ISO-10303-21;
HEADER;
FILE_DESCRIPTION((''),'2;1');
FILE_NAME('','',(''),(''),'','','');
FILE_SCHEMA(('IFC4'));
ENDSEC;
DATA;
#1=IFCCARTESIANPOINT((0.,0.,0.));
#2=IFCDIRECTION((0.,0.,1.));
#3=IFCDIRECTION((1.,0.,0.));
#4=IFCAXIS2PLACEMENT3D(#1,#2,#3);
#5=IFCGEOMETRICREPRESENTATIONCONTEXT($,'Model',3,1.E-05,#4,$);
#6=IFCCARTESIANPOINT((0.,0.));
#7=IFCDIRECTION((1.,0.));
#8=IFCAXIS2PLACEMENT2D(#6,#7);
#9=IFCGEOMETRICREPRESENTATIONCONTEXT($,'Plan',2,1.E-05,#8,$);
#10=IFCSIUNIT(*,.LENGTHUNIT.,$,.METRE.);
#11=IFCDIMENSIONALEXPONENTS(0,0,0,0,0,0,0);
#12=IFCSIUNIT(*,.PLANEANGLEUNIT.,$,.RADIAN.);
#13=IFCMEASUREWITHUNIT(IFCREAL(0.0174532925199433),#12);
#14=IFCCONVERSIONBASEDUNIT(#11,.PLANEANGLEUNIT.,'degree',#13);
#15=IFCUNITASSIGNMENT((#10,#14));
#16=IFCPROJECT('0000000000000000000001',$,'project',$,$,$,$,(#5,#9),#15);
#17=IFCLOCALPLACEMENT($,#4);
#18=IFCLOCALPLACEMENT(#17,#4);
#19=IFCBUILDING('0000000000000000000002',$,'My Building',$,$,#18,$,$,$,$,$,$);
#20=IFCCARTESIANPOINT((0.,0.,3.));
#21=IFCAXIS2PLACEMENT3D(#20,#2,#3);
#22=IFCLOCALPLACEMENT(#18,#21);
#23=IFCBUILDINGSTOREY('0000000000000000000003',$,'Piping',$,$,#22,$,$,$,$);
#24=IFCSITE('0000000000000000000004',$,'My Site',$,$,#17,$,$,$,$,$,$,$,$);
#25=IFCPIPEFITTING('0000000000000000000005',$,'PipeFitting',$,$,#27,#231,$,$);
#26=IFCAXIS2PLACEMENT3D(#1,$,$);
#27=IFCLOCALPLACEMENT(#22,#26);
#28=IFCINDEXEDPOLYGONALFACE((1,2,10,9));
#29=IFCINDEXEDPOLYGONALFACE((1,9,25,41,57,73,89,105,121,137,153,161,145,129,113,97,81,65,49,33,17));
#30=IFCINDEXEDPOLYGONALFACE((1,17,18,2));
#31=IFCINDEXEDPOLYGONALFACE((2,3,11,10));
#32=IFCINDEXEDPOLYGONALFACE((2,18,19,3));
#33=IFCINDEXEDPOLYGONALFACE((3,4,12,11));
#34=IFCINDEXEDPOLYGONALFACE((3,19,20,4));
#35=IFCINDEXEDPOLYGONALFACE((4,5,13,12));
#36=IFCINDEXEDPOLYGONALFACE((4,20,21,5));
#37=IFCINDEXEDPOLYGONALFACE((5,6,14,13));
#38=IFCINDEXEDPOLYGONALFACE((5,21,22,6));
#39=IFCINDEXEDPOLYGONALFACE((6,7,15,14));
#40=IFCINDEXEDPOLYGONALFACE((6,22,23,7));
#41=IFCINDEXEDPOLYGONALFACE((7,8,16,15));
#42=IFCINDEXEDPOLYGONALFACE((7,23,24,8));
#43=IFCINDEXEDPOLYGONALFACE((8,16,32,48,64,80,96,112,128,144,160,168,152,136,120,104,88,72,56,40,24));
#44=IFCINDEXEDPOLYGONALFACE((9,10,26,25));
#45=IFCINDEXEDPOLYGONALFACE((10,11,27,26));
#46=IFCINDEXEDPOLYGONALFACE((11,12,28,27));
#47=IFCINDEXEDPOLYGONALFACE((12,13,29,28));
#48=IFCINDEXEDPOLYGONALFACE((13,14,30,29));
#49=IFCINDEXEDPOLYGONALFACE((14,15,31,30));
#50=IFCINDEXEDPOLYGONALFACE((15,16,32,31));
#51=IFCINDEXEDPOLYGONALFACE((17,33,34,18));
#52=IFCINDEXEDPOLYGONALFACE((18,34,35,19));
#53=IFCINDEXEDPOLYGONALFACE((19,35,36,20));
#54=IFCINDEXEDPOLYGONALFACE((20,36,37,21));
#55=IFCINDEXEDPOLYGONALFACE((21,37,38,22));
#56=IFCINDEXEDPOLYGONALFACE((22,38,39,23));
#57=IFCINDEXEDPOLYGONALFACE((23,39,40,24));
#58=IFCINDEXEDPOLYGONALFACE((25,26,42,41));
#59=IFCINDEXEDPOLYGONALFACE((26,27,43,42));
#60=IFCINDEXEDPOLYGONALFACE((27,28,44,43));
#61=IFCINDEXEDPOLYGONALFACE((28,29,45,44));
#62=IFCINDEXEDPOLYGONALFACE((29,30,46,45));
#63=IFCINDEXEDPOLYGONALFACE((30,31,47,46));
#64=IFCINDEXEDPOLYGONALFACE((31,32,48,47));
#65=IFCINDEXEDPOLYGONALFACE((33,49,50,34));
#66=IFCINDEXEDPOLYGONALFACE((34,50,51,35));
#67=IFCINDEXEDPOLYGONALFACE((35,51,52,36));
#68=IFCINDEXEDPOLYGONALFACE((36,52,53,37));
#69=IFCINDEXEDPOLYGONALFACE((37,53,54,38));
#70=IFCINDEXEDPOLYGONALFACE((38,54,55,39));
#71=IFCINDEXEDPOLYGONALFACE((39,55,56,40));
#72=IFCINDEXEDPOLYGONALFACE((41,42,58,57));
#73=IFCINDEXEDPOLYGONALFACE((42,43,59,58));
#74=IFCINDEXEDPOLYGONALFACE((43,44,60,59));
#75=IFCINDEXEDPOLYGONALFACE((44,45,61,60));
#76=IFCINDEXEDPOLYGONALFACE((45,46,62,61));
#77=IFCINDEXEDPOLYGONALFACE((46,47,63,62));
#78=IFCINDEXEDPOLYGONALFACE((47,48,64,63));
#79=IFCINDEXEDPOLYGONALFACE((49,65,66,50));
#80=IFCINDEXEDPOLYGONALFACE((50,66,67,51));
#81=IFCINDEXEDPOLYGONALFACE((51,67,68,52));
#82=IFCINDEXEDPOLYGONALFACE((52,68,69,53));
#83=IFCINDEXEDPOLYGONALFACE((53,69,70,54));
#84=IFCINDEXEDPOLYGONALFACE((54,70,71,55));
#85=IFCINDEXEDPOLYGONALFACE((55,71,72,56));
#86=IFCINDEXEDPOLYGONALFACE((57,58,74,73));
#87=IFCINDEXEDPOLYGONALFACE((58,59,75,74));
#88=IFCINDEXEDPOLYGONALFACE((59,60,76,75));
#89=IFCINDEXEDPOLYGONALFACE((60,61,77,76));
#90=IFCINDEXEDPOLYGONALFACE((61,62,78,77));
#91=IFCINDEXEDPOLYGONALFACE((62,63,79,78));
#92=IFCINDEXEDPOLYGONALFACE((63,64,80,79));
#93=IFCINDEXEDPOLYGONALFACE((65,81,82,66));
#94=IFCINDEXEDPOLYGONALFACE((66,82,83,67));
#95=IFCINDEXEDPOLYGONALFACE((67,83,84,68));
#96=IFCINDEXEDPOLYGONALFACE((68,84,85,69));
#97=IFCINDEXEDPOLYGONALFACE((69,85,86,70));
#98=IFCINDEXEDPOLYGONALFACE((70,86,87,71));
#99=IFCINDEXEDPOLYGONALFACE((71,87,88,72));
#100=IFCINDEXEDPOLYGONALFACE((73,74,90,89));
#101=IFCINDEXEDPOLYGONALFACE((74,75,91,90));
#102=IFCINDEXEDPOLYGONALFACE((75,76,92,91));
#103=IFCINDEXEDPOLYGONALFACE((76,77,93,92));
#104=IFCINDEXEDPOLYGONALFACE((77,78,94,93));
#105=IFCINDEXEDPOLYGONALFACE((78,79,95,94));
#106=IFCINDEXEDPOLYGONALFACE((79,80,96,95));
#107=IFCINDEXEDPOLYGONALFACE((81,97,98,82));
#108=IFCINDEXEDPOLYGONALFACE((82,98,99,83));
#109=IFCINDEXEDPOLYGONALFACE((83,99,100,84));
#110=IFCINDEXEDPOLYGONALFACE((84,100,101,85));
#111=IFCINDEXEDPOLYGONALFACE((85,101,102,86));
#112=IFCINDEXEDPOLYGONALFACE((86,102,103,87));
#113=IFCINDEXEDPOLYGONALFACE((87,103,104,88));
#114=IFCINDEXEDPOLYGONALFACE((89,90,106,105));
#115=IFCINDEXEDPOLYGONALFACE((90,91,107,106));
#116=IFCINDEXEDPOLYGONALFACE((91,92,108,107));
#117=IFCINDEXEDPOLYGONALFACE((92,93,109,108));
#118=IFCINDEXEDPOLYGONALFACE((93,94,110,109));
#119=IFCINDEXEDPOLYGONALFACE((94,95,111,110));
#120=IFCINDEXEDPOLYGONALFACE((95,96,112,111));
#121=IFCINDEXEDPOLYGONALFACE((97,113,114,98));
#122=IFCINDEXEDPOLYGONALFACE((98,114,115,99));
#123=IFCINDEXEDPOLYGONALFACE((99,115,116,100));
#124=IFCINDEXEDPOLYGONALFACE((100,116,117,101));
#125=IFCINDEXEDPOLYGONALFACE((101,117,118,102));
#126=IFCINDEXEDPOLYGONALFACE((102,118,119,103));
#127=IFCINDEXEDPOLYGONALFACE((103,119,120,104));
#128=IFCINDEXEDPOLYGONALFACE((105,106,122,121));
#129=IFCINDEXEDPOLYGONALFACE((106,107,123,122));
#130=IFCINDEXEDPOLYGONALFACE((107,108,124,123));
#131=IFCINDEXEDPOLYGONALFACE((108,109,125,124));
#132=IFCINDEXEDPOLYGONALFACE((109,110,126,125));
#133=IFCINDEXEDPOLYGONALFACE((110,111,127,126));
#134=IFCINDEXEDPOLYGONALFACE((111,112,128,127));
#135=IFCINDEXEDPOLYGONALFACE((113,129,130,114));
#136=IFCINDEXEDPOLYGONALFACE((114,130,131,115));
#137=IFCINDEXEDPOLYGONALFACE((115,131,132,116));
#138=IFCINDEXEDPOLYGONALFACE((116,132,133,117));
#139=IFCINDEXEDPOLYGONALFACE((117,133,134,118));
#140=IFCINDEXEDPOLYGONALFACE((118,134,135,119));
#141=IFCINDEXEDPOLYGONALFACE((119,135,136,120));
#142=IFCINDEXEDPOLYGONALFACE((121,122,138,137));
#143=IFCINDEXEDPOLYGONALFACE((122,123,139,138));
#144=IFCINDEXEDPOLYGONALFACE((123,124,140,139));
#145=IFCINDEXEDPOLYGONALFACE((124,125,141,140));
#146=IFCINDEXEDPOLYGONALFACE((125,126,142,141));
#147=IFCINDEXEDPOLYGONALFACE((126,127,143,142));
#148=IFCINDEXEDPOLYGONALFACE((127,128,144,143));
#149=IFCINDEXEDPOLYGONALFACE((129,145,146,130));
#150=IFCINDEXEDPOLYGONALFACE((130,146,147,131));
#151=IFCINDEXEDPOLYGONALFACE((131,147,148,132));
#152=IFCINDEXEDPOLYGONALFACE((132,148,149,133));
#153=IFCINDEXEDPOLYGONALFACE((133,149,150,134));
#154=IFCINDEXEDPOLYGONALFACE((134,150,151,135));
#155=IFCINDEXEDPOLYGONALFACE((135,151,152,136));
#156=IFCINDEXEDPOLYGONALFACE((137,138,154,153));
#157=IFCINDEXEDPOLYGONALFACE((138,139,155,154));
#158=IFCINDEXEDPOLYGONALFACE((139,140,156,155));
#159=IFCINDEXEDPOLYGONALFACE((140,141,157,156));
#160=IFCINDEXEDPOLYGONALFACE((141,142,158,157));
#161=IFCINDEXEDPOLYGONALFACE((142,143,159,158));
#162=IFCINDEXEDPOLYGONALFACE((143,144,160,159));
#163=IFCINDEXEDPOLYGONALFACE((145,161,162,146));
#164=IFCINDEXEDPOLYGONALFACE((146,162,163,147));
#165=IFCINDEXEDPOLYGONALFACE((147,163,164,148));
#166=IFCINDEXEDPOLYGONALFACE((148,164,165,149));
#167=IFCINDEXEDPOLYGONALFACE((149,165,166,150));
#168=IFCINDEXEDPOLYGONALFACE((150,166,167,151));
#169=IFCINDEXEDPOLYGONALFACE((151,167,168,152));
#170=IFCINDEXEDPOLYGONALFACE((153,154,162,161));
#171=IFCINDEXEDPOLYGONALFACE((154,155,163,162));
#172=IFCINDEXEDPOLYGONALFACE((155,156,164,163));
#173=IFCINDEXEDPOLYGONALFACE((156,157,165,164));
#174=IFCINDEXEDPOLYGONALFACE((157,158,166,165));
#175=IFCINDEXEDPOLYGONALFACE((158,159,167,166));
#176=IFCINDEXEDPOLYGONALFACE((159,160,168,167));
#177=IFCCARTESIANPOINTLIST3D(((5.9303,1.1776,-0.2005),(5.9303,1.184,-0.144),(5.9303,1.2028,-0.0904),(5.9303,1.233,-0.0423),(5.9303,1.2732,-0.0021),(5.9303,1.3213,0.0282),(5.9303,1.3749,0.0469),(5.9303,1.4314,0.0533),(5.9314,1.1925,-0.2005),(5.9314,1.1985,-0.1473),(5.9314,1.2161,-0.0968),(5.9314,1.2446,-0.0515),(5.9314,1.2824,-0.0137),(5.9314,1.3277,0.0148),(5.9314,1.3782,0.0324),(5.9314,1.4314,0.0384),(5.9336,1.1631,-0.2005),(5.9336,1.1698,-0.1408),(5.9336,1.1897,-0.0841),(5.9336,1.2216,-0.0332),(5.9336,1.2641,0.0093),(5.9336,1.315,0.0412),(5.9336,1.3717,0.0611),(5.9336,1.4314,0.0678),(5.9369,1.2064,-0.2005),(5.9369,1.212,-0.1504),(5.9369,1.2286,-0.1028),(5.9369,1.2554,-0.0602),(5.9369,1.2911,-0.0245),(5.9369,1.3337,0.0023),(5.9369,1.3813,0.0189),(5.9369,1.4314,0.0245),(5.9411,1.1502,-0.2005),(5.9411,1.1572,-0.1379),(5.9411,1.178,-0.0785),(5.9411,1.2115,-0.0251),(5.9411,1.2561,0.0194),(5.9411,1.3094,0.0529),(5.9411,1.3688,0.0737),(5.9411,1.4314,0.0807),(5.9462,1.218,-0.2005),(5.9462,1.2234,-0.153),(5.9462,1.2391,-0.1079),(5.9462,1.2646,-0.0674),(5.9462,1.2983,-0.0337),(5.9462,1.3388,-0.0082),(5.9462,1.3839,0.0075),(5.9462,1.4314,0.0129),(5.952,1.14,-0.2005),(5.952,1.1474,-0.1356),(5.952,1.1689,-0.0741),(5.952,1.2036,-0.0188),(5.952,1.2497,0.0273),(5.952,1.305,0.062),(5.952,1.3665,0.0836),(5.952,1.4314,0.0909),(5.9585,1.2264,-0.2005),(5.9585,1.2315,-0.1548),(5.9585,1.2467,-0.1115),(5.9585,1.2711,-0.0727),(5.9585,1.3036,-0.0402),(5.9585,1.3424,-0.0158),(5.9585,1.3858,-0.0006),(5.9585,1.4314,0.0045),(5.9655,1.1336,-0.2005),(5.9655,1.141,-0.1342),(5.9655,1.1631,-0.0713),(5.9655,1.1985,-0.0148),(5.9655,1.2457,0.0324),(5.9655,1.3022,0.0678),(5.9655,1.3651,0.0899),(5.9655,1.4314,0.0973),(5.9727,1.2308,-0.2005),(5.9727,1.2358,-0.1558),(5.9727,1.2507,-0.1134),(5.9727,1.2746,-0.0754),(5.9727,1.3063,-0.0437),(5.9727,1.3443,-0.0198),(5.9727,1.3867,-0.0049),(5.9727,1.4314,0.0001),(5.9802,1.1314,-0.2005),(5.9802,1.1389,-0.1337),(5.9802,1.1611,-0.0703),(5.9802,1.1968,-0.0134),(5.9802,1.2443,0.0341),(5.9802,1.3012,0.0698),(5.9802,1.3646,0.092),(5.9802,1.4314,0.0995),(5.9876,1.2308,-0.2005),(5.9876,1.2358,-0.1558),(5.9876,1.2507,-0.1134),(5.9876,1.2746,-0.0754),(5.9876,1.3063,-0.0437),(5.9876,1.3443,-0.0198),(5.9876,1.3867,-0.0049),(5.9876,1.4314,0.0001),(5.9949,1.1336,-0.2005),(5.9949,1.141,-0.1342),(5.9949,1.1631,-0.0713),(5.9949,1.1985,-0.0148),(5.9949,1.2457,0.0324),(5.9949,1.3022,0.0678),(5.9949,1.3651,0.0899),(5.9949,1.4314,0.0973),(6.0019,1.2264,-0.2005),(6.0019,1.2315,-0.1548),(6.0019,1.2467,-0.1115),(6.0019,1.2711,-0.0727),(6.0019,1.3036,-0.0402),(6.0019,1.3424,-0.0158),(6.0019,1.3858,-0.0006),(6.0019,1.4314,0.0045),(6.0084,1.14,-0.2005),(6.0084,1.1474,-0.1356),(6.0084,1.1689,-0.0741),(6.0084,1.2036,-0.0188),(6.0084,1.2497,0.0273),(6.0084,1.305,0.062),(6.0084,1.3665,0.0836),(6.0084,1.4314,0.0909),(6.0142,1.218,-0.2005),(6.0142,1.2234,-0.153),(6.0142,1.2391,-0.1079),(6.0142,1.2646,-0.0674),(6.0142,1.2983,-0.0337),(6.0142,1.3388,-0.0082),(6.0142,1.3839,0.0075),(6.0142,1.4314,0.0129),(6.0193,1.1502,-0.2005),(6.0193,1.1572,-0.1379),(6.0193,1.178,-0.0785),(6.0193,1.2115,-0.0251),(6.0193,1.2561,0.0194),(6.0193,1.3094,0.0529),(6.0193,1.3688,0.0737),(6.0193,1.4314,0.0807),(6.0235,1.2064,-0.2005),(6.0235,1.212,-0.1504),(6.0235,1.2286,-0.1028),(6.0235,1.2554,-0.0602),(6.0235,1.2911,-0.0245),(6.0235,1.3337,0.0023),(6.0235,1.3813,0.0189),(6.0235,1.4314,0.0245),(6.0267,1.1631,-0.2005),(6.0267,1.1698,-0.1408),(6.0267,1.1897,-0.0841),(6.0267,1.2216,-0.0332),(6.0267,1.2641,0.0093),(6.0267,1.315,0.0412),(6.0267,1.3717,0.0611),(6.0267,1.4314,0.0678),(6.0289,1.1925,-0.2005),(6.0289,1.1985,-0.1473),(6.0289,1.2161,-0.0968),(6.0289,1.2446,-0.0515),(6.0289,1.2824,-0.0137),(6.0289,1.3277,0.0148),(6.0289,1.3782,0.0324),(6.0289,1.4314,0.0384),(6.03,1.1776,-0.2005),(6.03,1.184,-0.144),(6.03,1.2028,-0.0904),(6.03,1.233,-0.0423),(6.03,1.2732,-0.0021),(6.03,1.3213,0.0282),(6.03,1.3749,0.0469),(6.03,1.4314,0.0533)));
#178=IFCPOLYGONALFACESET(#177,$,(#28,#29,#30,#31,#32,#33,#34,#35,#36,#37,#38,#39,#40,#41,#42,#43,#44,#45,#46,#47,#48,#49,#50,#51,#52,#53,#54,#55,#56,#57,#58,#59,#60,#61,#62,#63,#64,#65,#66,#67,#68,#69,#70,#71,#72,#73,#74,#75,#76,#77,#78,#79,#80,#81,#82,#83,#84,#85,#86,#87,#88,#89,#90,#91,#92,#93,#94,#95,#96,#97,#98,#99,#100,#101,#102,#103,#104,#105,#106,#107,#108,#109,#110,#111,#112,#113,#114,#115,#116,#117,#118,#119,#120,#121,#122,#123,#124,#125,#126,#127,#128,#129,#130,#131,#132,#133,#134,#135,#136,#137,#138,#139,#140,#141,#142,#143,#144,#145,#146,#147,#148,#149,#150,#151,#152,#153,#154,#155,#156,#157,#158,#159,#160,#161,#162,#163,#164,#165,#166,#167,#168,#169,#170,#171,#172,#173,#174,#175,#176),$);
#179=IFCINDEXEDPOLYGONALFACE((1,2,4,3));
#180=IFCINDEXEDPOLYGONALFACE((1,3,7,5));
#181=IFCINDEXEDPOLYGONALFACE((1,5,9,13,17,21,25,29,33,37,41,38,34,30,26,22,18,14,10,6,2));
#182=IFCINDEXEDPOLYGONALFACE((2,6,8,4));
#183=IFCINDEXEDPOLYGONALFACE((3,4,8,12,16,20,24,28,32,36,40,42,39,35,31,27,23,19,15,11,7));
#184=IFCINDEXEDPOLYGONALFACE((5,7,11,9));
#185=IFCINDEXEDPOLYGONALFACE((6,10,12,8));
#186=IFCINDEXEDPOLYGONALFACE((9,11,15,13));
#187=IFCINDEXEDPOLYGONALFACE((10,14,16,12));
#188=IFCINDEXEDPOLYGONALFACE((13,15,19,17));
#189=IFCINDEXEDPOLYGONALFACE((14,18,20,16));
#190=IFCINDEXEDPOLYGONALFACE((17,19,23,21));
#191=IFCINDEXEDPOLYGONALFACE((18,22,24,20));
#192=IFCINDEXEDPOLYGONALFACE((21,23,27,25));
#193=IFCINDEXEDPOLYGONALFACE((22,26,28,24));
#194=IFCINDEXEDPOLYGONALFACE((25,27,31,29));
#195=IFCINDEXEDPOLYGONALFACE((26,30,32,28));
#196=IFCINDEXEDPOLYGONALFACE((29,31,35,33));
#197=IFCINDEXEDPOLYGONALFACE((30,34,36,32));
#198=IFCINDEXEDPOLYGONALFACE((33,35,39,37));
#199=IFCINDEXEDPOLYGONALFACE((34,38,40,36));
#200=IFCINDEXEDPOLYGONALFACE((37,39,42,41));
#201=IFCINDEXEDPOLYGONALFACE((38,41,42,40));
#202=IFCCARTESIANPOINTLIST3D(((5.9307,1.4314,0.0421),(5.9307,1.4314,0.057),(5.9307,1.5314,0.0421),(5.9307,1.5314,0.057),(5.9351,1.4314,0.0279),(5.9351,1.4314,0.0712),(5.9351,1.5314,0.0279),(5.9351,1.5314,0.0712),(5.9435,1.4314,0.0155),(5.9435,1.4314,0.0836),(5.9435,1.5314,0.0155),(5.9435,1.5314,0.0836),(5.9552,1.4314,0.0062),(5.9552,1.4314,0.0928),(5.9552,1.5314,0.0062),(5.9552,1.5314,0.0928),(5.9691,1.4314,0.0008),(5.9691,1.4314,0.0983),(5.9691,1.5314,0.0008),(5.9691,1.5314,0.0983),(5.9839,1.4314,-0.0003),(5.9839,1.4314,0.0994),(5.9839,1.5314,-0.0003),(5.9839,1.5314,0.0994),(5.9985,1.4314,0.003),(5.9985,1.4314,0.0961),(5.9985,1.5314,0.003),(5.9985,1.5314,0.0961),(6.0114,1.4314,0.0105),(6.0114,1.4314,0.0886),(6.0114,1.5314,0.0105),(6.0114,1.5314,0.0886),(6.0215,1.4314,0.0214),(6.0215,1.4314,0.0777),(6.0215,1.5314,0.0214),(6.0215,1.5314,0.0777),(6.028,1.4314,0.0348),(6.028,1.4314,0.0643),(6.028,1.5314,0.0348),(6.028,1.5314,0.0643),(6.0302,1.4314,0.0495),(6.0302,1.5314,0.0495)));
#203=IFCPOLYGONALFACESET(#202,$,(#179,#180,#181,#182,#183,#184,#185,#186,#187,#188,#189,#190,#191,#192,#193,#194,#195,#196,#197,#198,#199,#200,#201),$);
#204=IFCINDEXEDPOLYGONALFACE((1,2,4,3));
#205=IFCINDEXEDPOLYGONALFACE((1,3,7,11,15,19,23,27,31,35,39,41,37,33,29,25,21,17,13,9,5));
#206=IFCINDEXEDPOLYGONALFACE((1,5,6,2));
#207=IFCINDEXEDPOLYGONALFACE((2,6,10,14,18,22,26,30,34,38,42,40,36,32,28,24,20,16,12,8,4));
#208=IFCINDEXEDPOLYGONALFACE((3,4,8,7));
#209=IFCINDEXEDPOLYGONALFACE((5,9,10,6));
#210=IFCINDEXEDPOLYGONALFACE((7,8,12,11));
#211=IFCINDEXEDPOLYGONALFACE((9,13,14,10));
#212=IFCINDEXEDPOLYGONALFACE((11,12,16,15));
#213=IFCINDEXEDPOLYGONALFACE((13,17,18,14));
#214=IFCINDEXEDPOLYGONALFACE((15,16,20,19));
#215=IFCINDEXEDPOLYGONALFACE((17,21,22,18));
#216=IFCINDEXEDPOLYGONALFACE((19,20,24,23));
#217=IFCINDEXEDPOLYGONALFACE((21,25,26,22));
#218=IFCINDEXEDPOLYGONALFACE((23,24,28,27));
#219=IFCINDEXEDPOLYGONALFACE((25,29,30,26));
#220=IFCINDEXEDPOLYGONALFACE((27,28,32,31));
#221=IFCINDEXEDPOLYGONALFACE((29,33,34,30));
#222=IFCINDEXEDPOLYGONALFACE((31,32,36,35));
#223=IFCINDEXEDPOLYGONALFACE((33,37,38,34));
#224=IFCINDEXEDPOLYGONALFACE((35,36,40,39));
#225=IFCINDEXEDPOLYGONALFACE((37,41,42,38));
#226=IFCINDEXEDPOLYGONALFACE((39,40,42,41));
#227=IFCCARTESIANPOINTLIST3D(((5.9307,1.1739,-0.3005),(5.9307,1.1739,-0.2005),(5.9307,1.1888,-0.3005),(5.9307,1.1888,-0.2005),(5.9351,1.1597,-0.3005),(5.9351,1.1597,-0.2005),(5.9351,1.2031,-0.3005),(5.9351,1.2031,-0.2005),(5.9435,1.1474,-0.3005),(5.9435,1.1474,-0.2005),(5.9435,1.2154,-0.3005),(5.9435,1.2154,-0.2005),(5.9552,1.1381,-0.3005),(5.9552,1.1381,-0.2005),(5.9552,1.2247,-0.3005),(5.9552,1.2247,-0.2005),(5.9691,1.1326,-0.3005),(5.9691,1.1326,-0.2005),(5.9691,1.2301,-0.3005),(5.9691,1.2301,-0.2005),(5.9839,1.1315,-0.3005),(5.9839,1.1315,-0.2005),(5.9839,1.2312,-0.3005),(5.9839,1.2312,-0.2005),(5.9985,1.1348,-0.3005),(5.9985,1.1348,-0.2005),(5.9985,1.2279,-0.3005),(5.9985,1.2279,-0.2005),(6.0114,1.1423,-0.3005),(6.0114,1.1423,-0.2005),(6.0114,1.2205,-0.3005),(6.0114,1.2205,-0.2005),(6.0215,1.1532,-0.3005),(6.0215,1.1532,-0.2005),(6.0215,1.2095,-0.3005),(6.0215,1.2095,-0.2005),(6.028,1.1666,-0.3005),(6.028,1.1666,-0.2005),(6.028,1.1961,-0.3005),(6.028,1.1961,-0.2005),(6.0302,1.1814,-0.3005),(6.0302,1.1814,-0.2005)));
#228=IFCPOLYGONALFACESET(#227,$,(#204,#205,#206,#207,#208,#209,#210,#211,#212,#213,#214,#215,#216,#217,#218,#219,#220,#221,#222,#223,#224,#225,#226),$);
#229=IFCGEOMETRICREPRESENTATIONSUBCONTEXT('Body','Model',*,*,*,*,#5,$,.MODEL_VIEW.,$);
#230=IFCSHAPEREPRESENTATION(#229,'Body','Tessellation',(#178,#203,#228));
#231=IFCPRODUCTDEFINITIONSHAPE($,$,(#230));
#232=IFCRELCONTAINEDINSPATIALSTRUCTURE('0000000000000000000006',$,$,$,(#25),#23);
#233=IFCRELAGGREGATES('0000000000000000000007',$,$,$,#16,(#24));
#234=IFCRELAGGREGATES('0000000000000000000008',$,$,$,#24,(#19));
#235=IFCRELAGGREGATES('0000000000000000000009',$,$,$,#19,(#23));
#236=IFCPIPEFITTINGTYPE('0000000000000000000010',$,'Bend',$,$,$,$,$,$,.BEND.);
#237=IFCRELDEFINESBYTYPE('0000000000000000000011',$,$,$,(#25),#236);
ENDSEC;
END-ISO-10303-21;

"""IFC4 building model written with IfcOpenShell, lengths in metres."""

from ifc_helpers import new_model, entity, si_unit, converted_unit, frame, origin_with_axes, origin_2d_with_axis, place, context, subcontext, project, spatial, circle, extrude, source, transform, mapped, type_object, type_shapes, element, save


model = new_model("IFC4")

# Units and contexts
model_context = context("Model", 3, precision=1e-05, world=origin_with_axes())
plan_context = context("Plan", 2, precision=1e-05, world=origin_2d_with_axis())
body_context = subcontext(model_context, "Body", "Model", "MODEL_VIEW")
ifc_project = project(units=[si_unit("LENGTHUNIT", "METRE"), converted_unit("PLANEANGLEUNIT", "degree", entity("IfcReal", 0.0174532925199433), si_unit("PLANEANGLEUNIT", "RADIAN"), dimensions=[0, 0, 0, 0, 0, 0, 0])], contexts=[model_context, plan_context])

# Site, building, storey
site_placement = place(None, origin_with_axes())
site = spatial("IfcSite", under=ifc_project, at=site_placement, Name="My Site")
building_placement = place(site_placement, origin_with_axes())
building = spatial("IfcBuilding", under=site, at=building_placement, Name="My Building")
storey_placement = place(building_placement, frame((0.0, 0.0, 3.0), z_axis=(0.0, 0.0, 1.0), x_axis=(1.0, 0.0, 0.0)))
storey = spatial("IfcBuildingStorey", under=building, at=storey_placement, Name="Piping")

# Pipe fitting
pipe_fitting_type = type_object("IfcPipeFittingType", Name="Bend", PredefinedType="BEND")
shared_shape = source(origin_with_axes(), body_context, "Body", "SolidModel", [
    entity("IfcSweptDiskSolid", entity("IfcIndexedPolyCurve", entity("IfcCartesianPointList3D", [[0.0, 0.0, 0.1], [0.0, -0.0732, 0.2768], [0.0, -0.25, 0.35]]), [entity("IfcArcIndex", [1, 2, 3])]), 0.05),
    extrude(circle(Radius=0.05), origin_with_axes(), (0.0, 0.0, 1.0), 0.1),
    extrude(circle(Radius=0.05), frame((0.0, -0.25, 0.35), z_axis=(0.0, -1.0, 0.0), x_axis=(1.0, 0.0, 0.0)), (0.0, 0.0, 1.0), 0.1),
])
type_shapes(pipe_fitting_type, [shared_shape])
for number, where, z_axis, x_axis, name in (
    (1, (5.9802, 1.5314, 0.0495), (0.0, -1.0, 0.0), (1.0, 0.0, 0.0), "PipeFitting"),
):
    element("IfcPipeFitting", number, at=place(storey_placement, frame(where, z_axis=z_axis, x_axis=x_axis)), inside=storey, type_object=pipe_fitting_type, Name=name, context=body_context, shape_type="MappedRepresentation", body=[
        mapped(shared_shape, transform((0.0, 0.0, 0.0), x_axis=(1.0, 0.0, 0.0), y_axis=(0.0, 1.0, 0.0), z_axis=(0.0, 0.0, 1.0), scale=1.0)),
    ])

save(model, "model.ifc")
